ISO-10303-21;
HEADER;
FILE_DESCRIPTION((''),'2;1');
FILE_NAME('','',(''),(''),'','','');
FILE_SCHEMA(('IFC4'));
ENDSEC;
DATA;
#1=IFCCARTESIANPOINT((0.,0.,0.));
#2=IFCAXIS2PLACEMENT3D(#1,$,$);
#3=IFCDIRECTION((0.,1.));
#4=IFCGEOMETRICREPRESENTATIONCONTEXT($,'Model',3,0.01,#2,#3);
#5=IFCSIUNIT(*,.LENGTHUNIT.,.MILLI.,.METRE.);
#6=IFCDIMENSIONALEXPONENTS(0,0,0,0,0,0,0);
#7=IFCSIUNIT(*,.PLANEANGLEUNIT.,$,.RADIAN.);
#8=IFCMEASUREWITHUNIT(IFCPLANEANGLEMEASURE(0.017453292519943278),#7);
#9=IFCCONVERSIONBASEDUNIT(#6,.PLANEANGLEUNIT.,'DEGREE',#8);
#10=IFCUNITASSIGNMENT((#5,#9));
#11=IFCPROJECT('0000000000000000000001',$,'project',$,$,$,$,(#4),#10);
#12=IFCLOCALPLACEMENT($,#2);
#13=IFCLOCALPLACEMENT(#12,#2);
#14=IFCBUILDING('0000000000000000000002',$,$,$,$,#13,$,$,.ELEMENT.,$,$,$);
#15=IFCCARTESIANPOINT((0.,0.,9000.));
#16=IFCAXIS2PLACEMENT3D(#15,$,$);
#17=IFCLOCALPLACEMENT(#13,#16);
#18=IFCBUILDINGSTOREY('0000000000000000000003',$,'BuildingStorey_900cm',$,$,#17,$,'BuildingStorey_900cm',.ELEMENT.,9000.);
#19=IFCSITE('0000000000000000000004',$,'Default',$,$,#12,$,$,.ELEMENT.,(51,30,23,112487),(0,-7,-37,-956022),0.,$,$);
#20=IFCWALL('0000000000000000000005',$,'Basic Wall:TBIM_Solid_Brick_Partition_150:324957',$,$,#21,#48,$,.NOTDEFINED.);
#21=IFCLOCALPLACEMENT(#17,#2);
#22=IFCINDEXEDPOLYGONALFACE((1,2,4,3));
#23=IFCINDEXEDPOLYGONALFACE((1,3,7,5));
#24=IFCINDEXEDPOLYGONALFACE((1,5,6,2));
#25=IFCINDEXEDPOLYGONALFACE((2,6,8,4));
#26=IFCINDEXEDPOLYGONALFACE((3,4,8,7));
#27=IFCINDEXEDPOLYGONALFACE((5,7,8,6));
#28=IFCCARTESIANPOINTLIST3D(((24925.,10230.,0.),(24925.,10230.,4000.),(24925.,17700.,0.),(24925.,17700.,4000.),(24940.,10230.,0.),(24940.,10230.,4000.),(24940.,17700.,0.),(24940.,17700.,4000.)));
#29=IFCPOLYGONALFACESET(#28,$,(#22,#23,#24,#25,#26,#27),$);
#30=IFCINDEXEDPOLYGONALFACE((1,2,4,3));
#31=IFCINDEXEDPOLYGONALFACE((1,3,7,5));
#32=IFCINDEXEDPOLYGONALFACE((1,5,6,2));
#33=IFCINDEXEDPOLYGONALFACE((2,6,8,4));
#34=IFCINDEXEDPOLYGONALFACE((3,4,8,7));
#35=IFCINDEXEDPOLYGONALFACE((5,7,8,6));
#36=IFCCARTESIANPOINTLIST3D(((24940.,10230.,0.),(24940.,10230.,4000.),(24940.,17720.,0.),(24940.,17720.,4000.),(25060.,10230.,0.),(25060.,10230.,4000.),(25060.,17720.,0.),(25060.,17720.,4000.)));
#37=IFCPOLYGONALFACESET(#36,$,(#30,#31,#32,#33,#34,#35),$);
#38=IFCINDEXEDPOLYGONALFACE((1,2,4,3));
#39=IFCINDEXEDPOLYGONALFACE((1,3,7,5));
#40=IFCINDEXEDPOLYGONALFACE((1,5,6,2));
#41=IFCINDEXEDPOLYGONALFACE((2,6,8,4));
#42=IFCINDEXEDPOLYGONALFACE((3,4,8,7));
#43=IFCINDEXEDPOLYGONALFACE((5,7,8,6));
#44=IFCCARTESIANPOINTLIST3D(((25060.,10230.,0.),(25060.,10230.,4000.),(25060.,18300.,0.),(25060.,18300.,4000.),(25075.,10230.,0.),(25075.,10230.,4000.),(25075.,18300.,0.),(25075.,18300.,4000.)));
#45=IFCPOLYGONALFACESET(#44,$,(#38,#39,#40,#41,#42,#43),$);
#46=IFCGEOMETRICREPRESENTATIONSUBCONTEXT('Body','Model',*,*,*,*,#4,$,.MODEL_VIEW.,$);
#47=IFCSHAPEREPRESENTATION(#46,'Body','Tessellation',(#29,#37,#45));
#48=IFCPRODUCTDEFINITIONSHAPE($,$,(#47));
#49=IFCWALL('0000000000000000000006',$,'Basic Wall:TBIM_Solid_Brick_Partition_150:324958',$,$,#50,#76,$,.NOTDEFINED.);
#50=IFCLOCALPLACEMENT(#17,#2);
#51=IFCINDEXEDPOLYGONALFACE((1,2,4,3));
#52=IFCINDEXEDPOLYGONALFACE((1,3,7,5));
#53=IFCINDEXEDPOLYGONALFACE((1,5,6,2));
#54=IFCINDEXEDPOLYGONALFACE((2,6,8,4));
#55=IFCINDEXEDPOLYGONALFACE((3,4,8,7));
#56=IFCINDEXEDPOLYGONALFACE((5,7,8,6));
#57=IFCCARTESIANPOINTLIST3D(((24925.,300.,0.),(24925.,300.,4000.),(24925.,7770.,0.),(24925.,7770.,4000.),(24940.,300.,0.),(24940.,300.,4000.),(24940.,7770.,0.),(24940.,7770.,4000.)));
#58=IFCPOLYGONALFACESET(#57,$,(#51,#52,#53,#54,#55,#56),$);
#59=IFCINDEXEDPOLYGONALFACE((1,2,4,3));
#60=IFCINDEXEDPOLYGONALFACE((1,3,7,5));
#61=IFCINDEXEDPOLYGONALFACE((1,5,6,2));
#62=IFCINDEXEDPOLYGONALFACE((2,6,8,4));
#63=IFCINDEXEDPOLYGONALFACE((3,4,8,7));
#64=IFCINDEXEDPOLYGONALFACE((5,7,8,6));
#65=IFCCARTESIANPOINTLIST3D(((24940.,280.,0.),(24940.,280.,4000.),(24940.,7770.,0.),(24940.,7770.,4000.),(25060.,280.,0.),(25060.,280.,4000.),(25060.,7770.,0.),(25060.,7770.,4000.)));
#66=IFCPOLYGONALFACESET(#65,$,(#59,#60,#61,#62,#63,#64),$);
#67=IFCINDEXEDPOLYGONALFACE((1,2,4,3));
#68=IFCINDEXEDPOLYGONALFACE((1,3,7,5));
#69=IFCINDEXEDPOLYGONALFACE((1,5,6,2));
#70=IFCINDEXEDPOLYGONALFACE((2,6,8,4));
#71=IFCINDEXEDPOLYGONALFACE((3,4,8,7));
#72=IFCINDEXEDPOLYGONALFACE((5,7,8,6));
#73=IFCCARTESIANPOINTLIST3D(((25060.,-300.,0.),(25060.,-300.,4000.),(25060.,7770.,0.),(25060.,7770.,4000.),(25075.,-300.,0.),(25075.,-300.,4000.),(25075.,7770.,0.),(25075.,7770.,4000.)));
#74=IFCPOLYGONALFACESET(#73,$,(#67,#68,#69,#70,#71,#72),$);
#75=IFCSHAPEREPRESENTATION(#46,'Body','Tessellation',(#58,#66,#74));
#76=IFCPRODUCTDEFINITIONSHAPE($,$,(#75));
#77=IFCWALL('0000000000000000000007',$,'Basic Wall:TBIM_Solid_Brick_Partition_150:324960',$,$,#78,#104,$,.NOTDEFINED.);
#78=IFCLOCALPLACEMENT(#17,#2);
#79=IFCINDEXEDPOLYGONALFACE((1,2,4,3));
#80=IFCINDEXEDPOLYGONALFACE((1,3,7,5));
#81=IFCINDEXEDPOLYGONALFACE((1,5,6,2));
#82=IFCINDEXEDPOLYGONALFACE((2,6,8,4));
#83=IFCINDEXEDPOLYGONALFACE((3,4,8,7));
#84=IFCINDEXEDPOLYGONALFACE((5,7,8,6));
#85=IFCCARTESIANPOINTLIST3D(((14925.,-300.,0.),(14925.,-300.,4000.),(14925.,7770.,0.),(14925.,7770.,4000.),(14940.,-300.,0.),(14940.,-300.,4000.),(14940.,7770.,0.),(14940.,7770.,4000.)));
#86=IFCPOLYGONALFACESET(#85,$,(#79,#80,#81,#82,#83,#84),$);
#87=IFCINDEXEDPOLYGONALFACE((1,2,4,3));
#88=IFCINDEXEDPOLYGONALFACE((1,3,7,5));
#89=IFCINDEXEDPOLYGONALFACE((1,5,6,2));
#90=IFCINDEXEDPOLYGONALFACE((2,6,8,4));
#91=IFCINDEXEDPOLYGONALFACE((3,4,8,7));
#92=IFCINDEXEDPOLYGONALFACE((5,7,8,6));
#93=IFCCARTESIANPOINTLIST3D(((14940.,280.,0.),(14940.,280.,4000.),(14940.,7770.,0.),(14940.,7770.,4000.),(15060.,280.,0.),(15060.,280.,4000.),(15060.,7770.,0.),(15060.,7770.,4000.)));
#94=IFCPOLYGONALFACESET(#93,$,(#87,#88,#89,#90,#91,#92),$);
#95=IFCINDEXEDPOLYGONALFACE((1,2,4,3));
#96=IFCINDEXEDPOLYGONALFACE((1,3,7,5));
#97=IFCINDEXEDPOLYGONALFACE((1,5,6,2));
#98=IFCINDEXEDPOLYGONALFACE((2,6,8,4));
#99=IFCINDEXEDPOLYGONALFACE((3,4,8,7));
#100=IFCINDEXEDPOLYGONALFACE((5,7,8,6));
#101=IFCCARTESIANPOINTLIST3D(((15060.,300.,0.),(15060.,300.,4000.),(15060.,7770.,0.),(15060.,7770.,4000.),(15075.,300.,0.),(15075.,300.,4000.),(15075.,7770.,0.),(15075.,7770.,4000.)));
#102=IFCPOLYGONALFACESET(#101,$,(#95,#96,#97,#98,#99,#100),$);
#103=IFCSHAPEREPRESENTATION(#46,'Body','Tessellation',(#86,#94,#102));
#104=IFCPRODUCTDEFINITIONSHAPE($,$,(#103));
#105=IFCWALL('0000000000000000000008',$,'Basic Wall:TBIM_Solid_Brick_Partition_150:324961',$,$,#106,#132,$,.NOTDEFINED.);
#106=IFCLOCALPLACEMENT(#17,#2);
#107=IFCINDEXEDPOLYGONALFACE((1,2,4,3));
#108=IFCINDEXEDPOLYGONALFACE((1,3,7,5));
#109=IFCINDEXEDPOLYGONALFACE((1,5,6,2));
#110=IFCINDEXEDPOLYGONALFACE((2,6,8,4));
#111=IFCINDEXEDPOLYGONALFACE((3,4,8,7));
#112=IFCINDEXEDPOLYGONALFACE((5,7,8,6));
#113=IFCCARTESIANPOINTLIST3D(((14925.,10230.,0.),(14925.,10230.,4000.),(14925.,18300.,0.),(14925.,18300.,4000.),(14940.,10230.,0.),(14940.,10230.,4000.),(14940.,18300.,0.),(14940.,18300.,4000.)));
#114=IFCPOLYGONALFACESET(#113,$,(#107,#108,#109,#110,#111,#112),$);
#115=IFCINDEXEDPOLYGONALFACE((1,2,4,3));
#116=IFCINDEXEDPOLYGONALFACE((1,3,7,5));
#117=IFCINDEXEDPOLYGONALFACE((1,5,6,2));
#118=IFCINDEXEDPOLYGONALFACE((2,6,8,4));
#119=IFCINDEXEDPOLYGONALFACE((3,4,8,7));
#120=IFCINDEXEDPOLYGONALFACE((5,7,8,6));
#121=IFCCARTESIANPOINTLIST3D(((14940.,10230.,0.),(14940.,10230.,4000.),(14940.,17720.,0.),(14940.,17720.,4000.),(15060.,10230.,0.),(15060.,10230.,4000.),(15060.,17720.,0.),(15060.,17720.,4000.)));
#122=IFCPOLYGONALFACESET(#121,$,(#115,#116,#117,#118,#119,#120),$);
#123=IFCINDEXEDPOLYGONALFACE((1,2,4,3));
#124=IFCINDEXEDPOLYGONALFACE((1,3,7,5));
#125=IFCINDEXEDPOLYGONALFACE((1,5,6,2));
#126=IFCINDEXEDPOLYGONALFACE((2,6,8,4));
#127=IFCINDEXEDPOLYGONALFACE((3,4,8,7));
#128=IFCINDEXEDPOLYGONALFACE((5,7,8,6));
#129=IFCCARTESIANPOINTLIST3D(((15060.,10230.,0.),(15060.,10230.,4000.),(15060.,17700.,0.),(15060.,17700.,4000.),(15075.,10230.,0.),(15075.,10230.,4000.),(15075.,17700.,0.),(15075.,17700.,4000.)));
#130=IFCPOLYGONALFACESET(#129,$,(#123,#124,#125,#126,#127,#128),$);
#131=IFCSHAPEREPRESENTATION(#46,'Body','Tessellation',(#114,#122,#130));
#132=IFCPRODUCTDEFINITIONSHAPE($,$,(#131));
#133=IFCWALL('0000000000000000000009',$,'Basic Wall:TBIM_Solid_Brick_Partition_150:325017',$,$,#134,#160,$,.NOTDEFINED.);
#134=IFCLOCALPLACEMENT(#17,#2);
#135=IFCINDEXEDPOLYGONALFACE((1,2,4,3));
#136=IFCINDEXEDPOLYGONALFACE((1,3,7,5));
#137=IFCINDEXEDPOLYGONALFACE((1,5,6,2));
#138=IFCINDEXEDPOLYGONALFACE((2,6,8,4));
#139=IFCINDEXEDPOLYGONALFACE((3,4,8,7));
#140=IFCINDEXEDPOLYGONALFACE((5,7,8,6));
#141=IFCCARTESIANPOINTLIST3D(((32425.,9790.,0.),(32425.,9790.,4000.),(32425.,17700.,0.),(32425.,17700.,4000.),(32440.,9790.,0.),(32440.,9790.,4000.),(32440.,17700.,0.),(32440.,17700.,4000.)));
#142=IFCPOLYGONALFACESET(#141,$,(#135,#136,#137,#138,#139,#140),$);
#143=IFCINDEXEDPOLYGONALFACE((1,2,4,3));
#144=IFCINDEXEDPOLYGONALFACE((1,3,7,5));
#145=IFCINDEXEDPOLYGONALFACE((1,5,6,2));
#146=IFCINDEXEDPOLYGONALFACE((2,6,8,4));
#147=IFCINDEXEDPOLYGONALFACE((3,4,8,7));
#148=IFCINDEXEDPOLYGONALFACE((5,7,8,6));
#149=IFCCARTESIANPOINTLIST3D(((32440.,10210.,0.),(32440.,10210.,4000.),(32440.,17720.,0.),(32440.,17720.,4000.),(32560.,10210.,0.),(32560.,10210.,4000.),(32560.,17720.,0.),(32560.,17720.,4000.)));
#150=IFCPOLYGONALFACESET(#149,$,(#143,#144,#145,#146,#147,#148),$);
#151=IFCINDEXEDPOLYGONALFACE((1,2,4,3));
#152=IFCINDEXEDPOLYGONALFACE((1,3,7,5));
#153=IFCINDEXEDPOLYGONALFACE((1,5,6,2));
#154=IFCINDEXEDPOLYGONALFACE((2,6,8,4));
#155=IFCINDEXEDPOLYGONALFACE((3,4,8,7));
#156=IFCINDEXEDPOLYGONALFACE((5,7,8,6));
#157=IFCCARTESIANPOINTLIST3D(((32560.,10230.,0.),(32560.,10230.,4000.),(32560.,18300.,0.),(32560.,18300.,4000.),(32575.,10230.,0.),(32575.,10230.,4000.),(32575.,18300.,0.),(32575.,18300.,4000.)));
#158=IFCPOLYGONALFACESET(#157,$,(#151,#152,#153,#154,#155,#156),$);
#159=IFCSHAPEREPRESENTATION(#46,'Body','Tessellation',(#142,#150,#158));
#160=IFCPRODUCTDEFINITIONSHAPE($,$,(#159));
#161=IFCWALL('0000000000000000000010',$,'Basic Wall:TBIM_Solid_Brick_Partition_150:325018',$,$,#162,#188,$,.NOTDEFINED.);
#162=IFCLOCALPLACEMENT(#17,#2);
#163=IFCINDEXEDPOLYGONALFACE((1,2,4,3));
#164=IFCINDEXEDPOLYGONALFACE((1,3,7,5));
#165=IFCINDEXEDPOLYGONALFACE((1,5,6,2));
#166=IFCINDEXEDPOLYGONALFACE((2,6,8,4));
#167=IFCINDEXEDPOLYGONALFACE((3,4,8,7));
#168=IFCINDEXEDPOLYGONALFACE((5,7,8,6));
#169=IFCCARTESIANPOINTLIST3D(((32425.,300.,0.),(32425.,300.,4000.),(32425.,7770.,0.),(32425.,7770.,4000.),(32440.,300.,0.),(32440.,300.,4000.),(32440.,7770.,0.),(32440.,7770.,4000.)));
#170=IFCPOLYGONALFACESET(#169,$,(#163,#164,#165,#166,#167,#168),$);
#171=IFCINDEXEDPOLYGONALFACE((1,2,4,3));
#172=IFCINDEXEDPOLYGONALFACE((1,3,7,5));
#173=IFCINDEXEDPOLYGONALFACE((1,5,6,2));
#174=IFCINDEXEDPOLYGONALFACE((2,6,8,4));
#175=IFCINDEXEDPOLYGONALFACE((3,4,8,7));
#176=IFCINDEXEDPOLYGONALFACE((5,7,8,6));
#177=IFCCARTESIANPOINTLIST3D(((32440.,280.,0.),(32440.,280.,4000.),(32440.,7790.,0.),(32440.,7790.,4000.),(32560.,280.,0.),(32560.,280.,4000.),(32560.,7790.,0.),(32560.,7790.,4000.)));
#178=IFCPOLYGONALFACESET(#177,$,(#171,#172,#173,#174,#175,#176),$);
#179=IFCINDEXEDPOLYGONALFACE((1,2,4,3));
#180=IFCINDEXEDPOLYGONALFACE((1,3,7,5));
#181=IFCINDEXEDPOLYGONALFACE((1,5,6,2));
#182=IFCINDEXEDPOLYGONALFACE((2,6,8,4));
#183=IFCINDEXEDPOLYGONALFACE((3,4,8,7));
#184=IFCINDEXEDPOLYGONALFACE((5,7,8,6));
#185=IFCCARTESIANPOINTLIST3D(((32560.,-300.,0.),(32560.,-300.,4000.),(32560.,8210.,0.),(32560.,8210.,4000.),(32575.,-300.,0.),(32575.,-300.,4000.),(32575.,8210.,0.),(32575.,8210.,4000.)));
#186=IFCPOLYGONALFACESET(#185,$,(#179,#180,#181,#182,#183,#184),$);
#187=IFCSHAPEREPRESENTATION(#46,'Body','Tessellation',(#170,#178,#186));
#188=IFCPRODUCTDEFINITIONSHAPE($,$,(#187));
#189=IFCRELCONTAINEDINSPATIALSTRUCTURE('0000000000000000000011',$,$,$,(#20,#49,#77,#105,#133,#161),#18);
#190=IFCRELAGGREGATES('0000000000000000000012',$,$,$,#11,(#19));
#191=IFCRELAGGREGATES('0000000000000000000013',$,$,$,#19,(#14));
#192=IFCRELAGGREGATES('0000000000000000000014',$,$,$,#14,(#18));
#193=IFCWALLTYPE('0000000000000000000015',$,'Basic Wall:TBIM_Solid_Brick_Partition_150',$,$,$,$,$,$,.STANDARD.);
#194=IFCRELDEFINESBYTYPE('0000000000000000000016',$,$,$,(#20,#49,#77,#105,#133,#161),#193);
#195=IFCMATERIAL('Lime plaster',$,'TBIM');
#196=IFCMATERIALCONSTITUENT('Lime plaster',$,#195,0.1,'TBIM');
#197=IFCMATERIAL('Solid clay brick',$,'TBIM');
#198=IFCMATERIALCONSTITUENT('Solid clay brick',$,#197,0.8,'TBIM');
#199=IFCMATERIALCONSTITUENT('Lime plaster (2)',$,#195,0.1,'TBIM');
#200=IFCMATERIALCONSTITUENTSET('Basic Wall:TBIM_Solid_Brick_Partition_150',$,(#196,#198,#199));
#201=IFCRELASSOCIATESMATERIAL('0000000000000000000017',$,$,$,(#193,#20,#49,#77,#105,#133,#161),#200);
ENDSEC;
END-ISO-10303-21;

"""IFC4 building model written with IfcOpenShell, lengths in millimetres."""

from ifc_helpers import new_model, entity, si_unit, converted_unit, direction, frame, origin, place, context, subcontext, project, spatial, indexed_curve, outline, extrude, material, constituent, constituent_set, type_object, element, save


model = new_model("IFC4")

# Units and contexts
model_context = context("Model", 3, precision=0.01, world=origin(), true_north=direction((0.0, 1.0)))
body_context = subcontext(model_context, "Body", "Model", "MODEL_VIEW")
ifc_project = project(units=[si_unit("LENGTHUNIT", "METRE", prefix="MILLI"), converted_unit("PLANEANGLEUNIT", "DEGREE", entity("IfcPlaneAngleMeasure", 0.017453292519943278), si_unit("PLANEANGLEUNIT", "RADIAN"), dimensions=[0, 0, 0, 0, 0, 0, 0])], contexts=[model_context])

# Site, building, storey
site_placement = place(None, origin())
site = spatial("IfcSite", under=ifc_project, at=site_placement, Name="Default", CompositionType="ELEMENT", RefLatitude=(51, 30, 23, 112487), RefLongitude=(0, -7, -37, -956022), RefElevation=0.0)
building_placement = place(site_placement, origin())
building = spatial("IfcBuilding", under=site, at=building_placement, CompositionType="ELEMENT")
storey_placement = place(building_placement, frame((0.0, 0.0, 9000.0)))
storey = spatial("IfcBuildingStorey", under=building, at=storey_placement, Name="BuildingStorey_900cm", LongName="BuildingStorey_900cm", CompositionType="ELEMENT", Elevation=9000.0)

# Shared definitions
ifc_material_1 = material(Name="Solid clay brick", Category="TBIM")
ifc_material_2 = material(Name="Lime plaster", Category="TBIM")

# Walls
ifc_constituent_1 = constituent(ifc_material_2, Name="Lime plaster", Category="TBIM", fraction=0.1)
ifc_constituent_2 = constituent(ifc_material_1, Name="Solid clay brick", Category="TBIM", fraction=0.8)
ifc_constituent_3 = constituent(ifc_material_2, Name="Lime plaster (2)", Category="TBIM", fraction=0.1)
ifc_constituent_set_1 = constituent_set(constituents=[ifc_constituent_1, ifc_constituent_2, ifc_constituent_3], Name="Basic Wall:TBIM_Solid_Brick_Partition_150")
wall_type_1 = type_object("IfcWallType", Name="Basic Wall:TBIM_Solid_Brick_Partition_150", PredefinedType="STANDARD", material=ifc_constituent_set_1)
wall_1_placement = place(storey_placement, frame((25000.0, 10230.0, 0.0), z_axis=(0.0, 0.0, 1.0), x_axis=(0.0, 1.0, 0.0)))
element("IfcWall", 1, at=wall_1_placement, inside=storey, type_object=wall_type_1, material=ifc_constituent_set_1, Name="Basic Wall:TBIM_Solid_Brick_Partition_150:324957", PredefinedType="NOTDEFINED", context=body_context, shape_type="SweptSolid", body=[
    extrude(outline(indexed_curve([(-7.5, -3735.0), (7.5, -3735.0), (7.5, 3735.0), (-7.5, 3735.0), (-7.5, -3735.0)], self_intersect=False)), frame((3735.0, 67.5, 0.0), z_axis=(0.0, 0.0, 1.0), x_axis=(0.0, -1.0, 0.0)), (0.0, 0.0, 1.0), 4000.0),
    extrude(outline(indexed_curve([(-3745.0, -60.0), (3745.0, -60.0), (3745.0, 60.0), (-3745.0, 60.0), (-3745.0, -60.0)], self_intersect=False)), frame((3745.0, 0.0, 0.0)), (0.0, 0.0, 1.0), 4000.0),
    extrude(outline(indexed_curve([(-7.5, -4035.0), (7.5, -4035.0), (7.5, 4035.0), (-7.5, 4035.0), (-7.5, -4035.0)], self_intersect=False)), frame((4035.0, -67.5, 0.0), z_axis=(0.0, 0.0, 1.0), x_axis=(0.0, 1.0, 0.0)), (0.0, 0.0, 1.0), 4000.0),
])
wall_2_placement = place(storey_placement, frame((25000.0, 300.0, 0.0), z_axis=(0.0, 0.0, 1.0), x_axis=(0.0, 1.0, 0.0)))
element("IfcWall", 2, at=wall_2_placement, inside=storey, type_object=wall_type_1, material=ifc_constituent_set_1, Name="Basic Wall:TBIM_Solid_Brick_Partition_150:324958", PredefinedType="NOTDEFINED", context=body_context, shape_type="SweptSolid", body=[
    extrude(outline(indexed_curve([(-7.5, -3735.0), (7.5, -3735.0), (7.5, 3735.0), (-7.5, 3735.0), (-7.5, -3735.0)], self_intersect=False)), frame((3735.0, 67.5, 0.0), z_axis=(0.0, 0.0, 1.0), x_axis=(0.0, -1.0, 0.0)), (0.0, 0.0, 1.0), 4000.0),
    extrude(outline(indexed_curve([(-3745.0, -60.0), (3745.0, -60.0), (3745.0, 60.0), (-3745.0, 60.0), (-3745.0, -60.0)], self_intersect=False)), frame((3725.0, 0.0, 0.0)), (0.0, 0.0, 1.0), 4000.0),
    extrude(outline(indexed_curve([(-7.5, -4035.0), (7.5, -4035.0), (7.5, 4035.0), (-7.5, 4035.0), (-7.5, -4035.0)], self_intersect=False)), frame((3435.0, -67.5, 0.0), z_axis=(0.0, 0.0, 1.0), x_axis=(0.0, 1.0, 0.0)), (0.0, 0.0, 1.0), 4000.0),
])
wall_3_placement = place(storey_placement, frame((15000.0, 300.0, 0.0), z_axis=(0.0, 0.0, 1.0), x_axis=(0.0, 1.0, 0.0)))
element("IfcWall", 3, at=wall_3_placement, inside=storey, type_object=wall_type_1, material=ifc_constituent_set_1, Name="Basic Wall:TBIM_Solid_Brick_Partition_150:324960", PredefinedType="NOTDEFINED", context=body_context, shape_type="SweptSolid", body=[
    extrude(outline(indexed_curve([(-7.5, -4035.0), (7.5, -4035.0), (7.5, 4035.0), (-7.5, 4035.0), (-7.5, -4035.0)], self_intersect=False)), frame((3435.0, 67.5, 0.0), z_axis=(0.0, 0.0, 1.0), x_axis=(0.0, -1.0, 0.0)), (0.0, 0.0, 1.0), 4000.0),
    extrude(outline(indexed_curve([(-3745.0, -60.0), (3745.0, -60.0), (3745.0, 60.0), (-3745.0, 60.0), (-3745.0, -60.0)], self_intersect=False)), frame((3725.0, 0.0, 0.0)), (0.0, 0.0, 1.0), 4000.0),
    extrude(outline(indexed_curve([(-7.5, -3735.0), (7.5, -3735.0), (7.5, 3735.0), (-7.5, 3735.0), (-7.5, -3735.0)], self_intersect=False)), frame((3735.0, -67.5, 0.0), z_axis=(0.0, 0.0, 1.0), x_axis=(0.0, 1.0, 0.0)), (0.0, 0.0, 1.0), 4000.0),
])
wall_4_placement = place(storey_placement, frame((15000.0, 10230.0, 0.0), z_axis=(0.0, 0.0, 1.0), x_axis=(0.0, 1.0, 0.0)))
element("IfcWall", 4, at=wall_4_placement, inside=storey, type_object=wall_type_1, material=ifc_constituent_set_1, Name="Basic Wall:TBIM_Solid_Brick_Partition_150:324961", PredefinedType="NOTDEFINED", context=body_context, shape_type="SweptSolid", body=[
    extrude(outline(indexed_curve([(-7.5, -4035.0), (7.5, -4035.0), (7.5, 4035.0), (-7.5, 4035.0), (-7.5, -4035.0)], self_intersect=False)), frame((4035.0, 67.5, 0.0), z_axis=(0.0, 0.0, 1.0), x_axis=(0.0, -1.0, 0.0)), (0.0, 0.0, 1.0), 4000.0),
    extrude(outline(indexed_curve([(-3745.0, -60.0), (3745.0, -60.0), (3745.0, 60.0), (-3745.0, 60.0), (-3745.0, -60.0)], self_intersect=False)), frame((3745.0, 0.0, 0.0)), (0.0, 0.0, 1.0), 4000.0),
    extrude(outline(indexed_curve([(-7.5, -3735.0), (7.5, -3735.0), (7.5, 3735.0), (-7.5, 3735.0), (-7.5, -3735.0)], self_intersect=False)), frame((3735.0, -67.5, 0.0), z_axis=(0.0, 0.0, 1.0), x_axis=(0.0, 1.0, 0.0)), (0.0, 0.0, 1.0), 4000.0),
])
wall_5_placement = place(storey_placement, frame((32500.0, 10230.0, 0.0), z_axis=(0.0, 0.0, 1.0), x_axis=(0.0, 1.0, 0.0)))
element("IfcWall", 5, at=wall_5_placement, inside=storey, type_object=wall_type_1, material=ifc_constituent_set_1, Name="Basic Wall:TBIM_Solid_Brick_Partition_150:325017", PredefinedType="NOTDEFINED", context=body_context, shape_type="SweptSolid", body=[
    extrude(outline(indexed_curve([(-7.5, -3955.0), (7.5, -3955.0), (7.5, 3955.0), (-7.5, 3955.0), (-7.5, -3955.0)], self_intersect=False)), frame((3515.0, 67.5, 0.0), z_axis=(0.0, 0.0, 1.0), x_axis=(0.0, -1.0, 0.0)), (0.0, 0.0, 1.0), 4000.0),
    extrude(outline(indexed_curve([(-3755.0, -60.0), (3755.0, -60.0), (3755.0, 60.0), (-3755.0, 60.0), (-3755.0, -60.0)], self_intersect=False)), frame((3735.0, 0.0, 0.0)), (0.0, 0.0, 1.0), 4000.0),
    extrude(outline(indexed_curve([(-7.5, -4035.0), (7.5, -4035.0), (7.5, 4035.0), (-7.5, 4035.0), (-7.5, -4035.0)], self_intersect=False)), frame((4035.0, -67.5, 0.0), z_axis=(0.0, 0.0, 1.0), x_axis=(0.0, 1.0, 0.0)), (0.0, 0.0, 1.0), 4000.0),
])
wall_6_placement = place(storey_placement, frame((32500.0, 300.0, 0.0), z_axis=(0.0, 0.0, 1.0), x_axis=(0.0, 1.0, 0.0)))
element("IfcWall", 6, at=wall_6_placement, inside=storey, type_object=wall_type_1, material=ifc_constituent_set_1, Name="Basic Wall:TBIM_Solid_Brick_Partition_150:325018", PredefinedType="NOTDEFINED", context=body_context, shape_type="SweptSolid", body=[
    extrude(outline(indexed_curve([(-7.5, -3735.0), (7.5, -3735.0), (7.5, 3735.0), (-7.5, 3735.0), (-7.5, -3735.0)], self_intersect=False)), frame((3735.0, 67.5, 0.0), z_axis=(0.0, 0.0, 1.0), x_axis=(0.0, -1.0, 0.0)), (0.0, 0.0, 1.0), 4000.0),
    extrude(outline(indexed_curve([(-3755.0, -60.0), (3755.0, -60.0), (3755.0, 60.0), (-3755.0, 60.0), (-3755.0, -60.0)], self_intersect=False)), frame((3735.0, 0.0, 0.0)), (0.0, 0.0, 1.0), 4000.0),
    extrude(outline(indexed_curve([(-7.5, -4255.0), (7.5, -4255.0), (7.5, 4255.0), (-7.5, 4255.0), (-7.5, -4255.0)], self_intersect=False)), frame((3655.0, -67.5, 0.0), z_axis=(0.0, 0.0, 1.0), x_axis=(0.0, 1.0, 0.0)), (0.0, 0.0, 1.0), 4000.0),
])

save(model, "model.ifc")
